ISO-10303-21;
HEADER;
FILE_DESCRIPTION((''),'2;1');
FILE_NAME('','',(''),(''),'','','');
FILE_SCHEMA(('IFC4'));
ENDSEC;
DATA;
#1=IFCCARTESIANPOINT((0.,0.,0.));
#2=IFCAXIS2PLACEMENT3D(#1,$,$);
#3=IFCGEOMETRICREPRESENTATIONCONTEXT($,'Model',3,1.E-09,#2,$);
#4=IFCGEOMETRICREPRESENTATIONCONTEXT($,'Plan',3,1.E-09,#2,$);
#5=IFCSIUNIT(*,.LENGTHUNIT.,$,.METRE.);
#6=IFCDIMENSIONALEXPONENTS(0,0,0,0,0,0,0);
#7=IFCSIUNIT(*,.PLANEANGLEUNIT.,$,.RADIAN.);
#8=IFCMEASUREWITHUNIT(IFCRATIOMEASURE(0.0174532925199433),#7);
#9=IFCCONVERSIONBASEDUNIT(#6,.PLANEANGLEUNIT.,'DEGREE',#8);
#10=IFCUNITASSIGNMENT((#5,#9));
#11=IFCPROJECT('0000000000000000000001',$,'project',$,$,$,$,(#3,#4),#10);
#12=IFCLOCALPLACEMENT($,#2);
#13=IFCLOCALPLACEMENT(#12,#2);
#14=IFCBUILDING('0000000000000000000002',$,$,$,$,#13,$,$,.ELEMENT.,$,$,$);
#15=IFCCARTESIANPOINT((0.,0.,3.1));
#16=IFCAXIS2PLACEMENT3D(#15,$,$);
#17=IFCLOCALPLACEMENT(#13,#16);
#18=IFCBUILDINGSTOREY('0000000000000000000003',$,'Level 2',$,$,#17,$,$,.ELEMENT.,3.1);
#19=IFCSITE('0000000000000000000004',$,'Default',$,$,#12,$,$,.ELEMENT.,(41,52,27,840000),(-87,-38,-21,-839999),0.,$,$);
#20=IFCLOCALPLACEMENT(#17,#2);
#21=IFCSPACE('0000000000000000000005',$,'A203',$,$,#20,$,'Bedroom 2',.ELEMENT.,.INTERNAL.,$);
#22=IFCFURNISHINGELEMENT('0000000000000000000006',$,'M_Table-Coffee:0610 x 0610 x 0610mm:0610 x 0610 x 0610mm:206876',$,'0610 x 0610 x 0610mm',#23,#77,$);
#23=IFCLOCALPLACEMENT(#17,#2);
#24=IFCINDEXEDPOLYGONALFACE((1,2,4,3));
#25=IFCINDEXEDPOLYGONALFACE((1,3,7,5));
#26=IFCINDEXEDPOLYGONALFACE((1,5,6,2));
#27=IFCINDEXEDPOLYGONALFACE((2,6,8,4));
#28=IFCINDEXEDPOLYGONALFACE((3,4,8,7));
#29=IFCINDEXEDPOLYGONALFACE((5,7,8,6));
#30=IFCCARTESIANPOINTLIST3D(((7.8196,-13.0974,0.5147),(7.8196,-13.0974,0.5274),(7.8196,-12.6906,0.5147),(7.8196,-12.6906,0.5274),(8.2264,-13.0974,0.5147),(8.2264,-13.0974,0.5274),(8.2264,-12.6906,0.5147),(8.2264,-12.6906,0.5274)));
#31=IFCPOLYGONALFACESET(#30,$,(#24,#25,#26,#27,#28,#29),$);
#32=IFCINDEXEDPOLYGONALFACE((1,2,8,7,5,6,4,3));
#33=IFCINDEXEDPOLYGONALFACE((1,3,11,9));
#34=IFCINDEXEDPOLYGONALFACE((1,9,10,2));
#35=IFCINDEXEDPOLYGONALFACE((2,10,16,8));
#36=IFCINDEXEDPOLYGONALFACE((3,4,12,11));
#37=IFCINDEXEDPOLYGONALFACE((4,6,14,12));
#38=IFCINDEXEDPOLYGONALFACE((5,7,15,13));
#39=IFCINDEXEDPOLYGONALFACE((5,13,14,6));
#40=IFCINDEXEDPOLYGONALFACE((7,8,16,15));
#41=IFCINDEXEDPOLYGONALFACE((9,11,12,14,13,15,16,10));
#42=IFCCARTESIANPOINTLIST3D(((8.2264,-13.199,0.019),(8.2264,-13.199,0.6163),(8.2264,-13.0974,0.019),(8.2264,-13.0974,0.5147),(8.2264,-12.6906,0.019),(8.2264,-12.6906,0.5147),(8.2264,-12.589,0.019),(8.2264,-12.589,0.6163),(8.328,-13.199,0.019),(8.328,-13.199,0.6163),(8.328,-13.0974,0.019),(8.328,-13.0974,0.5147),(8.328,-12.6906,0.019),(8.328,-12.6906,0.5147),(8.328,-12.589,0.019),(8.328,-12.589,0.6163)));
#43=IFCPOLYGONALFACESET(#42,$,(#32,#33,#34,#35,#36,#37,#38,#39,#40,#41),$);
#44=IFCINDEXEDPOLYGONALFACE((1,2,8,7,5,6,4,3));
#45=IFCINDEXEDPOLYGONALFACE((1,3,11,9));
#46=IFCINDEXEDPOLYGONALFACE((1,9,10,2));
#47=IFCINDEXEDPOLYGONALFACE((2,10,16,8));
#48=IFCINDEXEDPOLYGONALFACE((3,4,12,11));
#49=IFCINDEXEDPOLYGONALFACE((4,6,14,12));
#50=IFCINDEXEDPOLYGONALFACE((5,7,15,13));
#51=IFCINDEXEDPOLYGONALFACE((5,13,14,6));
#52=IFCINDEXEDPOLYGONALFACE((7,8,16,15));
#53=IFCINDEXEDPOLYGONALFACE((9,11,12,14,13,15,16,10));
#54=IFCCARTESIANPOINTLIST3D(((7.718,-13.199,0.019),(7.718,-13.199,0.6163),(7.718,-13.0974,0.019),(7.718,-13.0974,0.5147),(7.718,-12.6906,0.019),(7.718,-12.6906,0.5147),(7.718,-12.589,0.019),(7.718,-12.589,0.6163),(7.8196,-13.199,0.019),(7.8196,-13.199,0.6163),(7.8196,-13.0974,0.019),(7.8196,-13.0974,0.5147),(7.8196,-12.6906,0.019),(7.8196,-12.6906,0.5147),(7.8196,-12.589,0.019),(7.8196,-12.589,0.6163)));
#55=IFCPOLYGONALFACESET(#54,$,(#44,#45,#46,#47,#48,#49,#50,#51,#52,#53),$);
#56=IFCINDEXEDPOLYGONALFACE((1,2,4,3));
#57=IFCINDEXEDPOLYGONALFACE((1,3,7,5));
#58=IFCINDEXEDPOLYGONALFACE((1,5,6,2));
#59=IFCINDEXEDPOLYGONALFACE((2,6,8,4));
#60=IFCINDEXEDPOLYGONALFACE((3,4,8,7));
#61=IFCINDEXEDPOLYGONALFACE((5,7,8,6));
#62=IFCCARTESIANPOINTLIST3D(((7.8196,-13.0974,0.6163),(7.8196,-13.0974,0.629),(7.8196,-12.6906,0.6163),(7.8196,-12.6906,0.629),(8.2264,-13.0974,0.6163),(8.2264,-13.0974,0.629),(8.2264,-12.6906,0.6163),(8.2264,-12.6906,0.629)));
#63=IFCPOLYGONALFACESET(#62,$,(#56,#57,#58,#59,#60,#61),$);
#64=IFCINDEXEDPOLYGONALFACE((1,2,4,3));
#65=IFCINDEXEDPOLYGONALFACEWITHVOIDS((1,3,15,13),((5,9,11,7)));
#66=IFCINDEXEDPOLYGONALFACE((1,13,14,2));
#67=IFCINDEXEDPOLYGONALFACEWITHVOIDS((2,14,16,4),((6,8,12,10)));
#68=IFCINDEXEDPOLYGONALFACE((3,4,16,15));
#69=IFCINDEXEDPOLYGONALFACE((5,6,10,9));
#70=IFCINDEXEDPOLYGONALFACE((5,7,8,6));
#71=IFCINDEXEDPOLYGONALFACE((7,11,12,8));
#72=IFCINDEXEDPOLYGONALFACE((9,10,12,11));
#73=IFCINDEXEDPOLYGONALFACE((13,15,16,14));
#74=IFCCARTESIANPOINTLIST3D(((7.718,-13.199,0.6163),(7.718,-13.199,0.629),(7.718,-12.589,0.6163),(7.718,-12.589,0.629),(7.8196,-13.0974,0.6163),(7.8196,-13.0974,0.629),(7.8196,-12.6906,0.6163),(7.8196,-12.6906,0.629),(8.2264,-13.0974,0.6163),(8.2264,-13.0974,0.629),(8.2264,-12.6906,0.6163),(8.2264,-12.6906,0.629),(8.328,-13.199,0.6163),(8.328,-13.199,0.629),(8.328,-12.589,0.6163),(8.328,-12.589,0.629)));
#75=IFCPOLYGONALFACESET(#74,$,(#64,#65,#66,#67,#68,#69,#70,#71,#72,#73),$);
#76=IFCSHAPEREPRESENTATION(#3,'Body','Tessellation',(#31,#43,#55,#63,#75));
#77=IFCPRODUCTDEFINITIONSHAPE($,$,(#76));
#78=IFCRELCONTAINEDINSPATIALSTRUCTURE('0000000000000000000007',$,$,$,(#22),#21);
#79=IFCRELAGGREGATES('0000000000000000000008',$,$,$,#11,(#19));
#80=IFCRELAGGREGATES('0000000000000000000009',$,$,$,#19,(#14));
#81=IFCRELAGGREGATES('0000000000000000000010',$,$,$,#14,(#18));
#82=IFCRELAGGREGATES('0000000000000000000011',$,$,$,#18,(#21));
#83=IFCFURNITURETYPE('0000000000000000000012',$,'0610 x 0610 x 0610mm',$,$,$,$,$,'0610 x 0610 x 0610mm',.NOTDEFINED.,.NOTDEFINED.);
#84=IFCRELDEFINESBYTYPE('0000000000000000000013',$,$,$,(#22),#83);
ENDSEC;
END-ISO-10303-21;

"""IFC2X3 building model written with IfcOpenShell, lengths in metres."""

from ifc_helpers import new_model, entity, si_unit, converted_unit, frame, origin, origin_2d_with_axis, place, context, project, spatial, polyline, rectangle, outline, extrude, source, transform, mapped, type_object, type_shapes, element, save


model = new_model("IFC2X3")

# Units and contexts
model_context = context("Model", 3, precision=1e-09, world=origin())
plan_context = context("Plan", 3, precision=1e-09, world=origin())
ifc_project = project(units=[si_unit("LENGTHUNIT", "METRE"), converted_unit("PLANEANGLEUNIT", "DEGREE", entity("IfcRatioMeasure", 0.0174532925199433), si_unit("PLANEANGLEUNIT", "RADIAN"), dimensions=[0, 0, 0, 0, 0, 0, 0])], contexts=[model_context, plan_context])

# Site, building, storey
site_placement = place(None, origin())
site = spatial("IfcSite", under=ifc_project, at=site_placement, Name="Default", CompositionType="ELEMENT", RefLatitude=(41, 52, 27, 840000), RefLongitude=(-87, -38, -21, -839999), RefElevation=0.0)
building_placement = place(site_placement, origin())
building = spatial("IfcBuilding", under=site, at=building_placement, CompositionType="ELEMENT")
storey_placement = place(building_placement, frame((0.0, 0.0, 3.1)))
storey = spatial("IfcBuildingStorey", under=building, at=storey_placement, Name="Level 2", CompositionType="ELEMENT", Elevation=3.1)

# Shared definitions
space_placement = place(storey_placement, origin())
space = spatial("IfcSpace", under=storey, at=space_placement, Name="A203", LongName="Bedroom 2", CompositionType="ELEMENT", InteriorOrExteriorSpace="INTERNAL")

# Furnishing element
furniture_type = type_object("IfcFurnitureType", Name="0610 x 0610 x 0610mm", ElementType="0610 x 0610 x 0610mm", AssemblyPlace="NOTDEFINED")
shared_shape_1 = source(origin(), model_context, "Body", "SweptSolid", [
    extrude(rectangle(XDim=0.4068, YDim=0.4068, at=origin_2d_with_axis()), frame((0.0183, 0.0952, 0.4957), z_axis=(0.0, 0.0, 1.0), x_axis=(-1.0, 0.0, 0.0)), (0.0, 0.0, 1.0), 0.0127),
    extrude(outline(polyline([(-0.2732, -0.305), (0.324, -0.305), (0.324, 0.305), (-0.2732, 0.305), (-0.2732, 0.2034), (0.2225, 0.2034), (0.2225, -0.2034), (-0.2732, -0.2034), (-0.2732, -0.305)])), frame((0.2217, 0.0952, 0.2732), z_axis=(1.0, 0.0, 0.0), x_axis=(0.0, 0.0, 1.0)), (0.0, 0.0, 1.0), 0.1016),
    extrude(outline(polyline([(-0.305, -0.3241), (0.305, -0.3241), (0.305, 0.2733), (0.2034, 0.2733), (0.2034, -0.2224), (-0.2034, -0.2224), (-0.2034, 0.2733), (-0.305, 0.2733), (-0.305, -0.3241)])), frame((-0.2867, 0.0952, 0.2733), z_axis=(1.0, 0.0, 0.0), x_axis=(0.0, -1.0, 0.0)), (0.0, 0.0, 1.0), 0.1016),
    extrude(rectangle(XDim=0.4068, YDim=0.4068, at=origin_2d_with_axis()), frame((0.0183, 0.0952, 0.5973), z_axis=(0.0, 0.0, 1.0), x_axis=(-1.0, 0.0, 0.0)), (0.0, 0.0, 1.0), 0.0127),
    extrude(outline(polyline([(-0.305, -0.305), (0.305, -0.305), (0.305, 0.305), (-0.305, 0.305), (-0.305, -0.305)]), holes=[polyline([(-0.2034, -0.2034), (-0.2034, 0.2034), (0.2034, 0.2034), (0.2034, -0.2034), (-0.2034, -0.2034)])]), frame((0.0183, 0.0952, 0.5973), z_axis=(0.0, 0.0, 1.0), x_axis=(-1.0, 0.0, 0.0)), (0.0, 0.0, 1.0), 0.0127),
])
type_shapes(furniture_type, [shared_shape_1])
furnishing_placement = place(space_placement, frame((8.0047, -12.9892, 0.019)))
element("IfcFurnishingElement", 1, at=furnishing_placement, inside=space, type_object=furniture_type, Name="M_Table-Coffee:0610 x 0610 x 0610mm:0610 x 0610 x 0610mm:206876", ObjectType="0610 x 0610 x 0610mm", context=model_context, shape_type="MappedRepresentation", body=[
    mapped(shared_shape_1, transform((0.0, 0.0, 0.0), scale=1.0)),
])

save(model, "model.ifc")
